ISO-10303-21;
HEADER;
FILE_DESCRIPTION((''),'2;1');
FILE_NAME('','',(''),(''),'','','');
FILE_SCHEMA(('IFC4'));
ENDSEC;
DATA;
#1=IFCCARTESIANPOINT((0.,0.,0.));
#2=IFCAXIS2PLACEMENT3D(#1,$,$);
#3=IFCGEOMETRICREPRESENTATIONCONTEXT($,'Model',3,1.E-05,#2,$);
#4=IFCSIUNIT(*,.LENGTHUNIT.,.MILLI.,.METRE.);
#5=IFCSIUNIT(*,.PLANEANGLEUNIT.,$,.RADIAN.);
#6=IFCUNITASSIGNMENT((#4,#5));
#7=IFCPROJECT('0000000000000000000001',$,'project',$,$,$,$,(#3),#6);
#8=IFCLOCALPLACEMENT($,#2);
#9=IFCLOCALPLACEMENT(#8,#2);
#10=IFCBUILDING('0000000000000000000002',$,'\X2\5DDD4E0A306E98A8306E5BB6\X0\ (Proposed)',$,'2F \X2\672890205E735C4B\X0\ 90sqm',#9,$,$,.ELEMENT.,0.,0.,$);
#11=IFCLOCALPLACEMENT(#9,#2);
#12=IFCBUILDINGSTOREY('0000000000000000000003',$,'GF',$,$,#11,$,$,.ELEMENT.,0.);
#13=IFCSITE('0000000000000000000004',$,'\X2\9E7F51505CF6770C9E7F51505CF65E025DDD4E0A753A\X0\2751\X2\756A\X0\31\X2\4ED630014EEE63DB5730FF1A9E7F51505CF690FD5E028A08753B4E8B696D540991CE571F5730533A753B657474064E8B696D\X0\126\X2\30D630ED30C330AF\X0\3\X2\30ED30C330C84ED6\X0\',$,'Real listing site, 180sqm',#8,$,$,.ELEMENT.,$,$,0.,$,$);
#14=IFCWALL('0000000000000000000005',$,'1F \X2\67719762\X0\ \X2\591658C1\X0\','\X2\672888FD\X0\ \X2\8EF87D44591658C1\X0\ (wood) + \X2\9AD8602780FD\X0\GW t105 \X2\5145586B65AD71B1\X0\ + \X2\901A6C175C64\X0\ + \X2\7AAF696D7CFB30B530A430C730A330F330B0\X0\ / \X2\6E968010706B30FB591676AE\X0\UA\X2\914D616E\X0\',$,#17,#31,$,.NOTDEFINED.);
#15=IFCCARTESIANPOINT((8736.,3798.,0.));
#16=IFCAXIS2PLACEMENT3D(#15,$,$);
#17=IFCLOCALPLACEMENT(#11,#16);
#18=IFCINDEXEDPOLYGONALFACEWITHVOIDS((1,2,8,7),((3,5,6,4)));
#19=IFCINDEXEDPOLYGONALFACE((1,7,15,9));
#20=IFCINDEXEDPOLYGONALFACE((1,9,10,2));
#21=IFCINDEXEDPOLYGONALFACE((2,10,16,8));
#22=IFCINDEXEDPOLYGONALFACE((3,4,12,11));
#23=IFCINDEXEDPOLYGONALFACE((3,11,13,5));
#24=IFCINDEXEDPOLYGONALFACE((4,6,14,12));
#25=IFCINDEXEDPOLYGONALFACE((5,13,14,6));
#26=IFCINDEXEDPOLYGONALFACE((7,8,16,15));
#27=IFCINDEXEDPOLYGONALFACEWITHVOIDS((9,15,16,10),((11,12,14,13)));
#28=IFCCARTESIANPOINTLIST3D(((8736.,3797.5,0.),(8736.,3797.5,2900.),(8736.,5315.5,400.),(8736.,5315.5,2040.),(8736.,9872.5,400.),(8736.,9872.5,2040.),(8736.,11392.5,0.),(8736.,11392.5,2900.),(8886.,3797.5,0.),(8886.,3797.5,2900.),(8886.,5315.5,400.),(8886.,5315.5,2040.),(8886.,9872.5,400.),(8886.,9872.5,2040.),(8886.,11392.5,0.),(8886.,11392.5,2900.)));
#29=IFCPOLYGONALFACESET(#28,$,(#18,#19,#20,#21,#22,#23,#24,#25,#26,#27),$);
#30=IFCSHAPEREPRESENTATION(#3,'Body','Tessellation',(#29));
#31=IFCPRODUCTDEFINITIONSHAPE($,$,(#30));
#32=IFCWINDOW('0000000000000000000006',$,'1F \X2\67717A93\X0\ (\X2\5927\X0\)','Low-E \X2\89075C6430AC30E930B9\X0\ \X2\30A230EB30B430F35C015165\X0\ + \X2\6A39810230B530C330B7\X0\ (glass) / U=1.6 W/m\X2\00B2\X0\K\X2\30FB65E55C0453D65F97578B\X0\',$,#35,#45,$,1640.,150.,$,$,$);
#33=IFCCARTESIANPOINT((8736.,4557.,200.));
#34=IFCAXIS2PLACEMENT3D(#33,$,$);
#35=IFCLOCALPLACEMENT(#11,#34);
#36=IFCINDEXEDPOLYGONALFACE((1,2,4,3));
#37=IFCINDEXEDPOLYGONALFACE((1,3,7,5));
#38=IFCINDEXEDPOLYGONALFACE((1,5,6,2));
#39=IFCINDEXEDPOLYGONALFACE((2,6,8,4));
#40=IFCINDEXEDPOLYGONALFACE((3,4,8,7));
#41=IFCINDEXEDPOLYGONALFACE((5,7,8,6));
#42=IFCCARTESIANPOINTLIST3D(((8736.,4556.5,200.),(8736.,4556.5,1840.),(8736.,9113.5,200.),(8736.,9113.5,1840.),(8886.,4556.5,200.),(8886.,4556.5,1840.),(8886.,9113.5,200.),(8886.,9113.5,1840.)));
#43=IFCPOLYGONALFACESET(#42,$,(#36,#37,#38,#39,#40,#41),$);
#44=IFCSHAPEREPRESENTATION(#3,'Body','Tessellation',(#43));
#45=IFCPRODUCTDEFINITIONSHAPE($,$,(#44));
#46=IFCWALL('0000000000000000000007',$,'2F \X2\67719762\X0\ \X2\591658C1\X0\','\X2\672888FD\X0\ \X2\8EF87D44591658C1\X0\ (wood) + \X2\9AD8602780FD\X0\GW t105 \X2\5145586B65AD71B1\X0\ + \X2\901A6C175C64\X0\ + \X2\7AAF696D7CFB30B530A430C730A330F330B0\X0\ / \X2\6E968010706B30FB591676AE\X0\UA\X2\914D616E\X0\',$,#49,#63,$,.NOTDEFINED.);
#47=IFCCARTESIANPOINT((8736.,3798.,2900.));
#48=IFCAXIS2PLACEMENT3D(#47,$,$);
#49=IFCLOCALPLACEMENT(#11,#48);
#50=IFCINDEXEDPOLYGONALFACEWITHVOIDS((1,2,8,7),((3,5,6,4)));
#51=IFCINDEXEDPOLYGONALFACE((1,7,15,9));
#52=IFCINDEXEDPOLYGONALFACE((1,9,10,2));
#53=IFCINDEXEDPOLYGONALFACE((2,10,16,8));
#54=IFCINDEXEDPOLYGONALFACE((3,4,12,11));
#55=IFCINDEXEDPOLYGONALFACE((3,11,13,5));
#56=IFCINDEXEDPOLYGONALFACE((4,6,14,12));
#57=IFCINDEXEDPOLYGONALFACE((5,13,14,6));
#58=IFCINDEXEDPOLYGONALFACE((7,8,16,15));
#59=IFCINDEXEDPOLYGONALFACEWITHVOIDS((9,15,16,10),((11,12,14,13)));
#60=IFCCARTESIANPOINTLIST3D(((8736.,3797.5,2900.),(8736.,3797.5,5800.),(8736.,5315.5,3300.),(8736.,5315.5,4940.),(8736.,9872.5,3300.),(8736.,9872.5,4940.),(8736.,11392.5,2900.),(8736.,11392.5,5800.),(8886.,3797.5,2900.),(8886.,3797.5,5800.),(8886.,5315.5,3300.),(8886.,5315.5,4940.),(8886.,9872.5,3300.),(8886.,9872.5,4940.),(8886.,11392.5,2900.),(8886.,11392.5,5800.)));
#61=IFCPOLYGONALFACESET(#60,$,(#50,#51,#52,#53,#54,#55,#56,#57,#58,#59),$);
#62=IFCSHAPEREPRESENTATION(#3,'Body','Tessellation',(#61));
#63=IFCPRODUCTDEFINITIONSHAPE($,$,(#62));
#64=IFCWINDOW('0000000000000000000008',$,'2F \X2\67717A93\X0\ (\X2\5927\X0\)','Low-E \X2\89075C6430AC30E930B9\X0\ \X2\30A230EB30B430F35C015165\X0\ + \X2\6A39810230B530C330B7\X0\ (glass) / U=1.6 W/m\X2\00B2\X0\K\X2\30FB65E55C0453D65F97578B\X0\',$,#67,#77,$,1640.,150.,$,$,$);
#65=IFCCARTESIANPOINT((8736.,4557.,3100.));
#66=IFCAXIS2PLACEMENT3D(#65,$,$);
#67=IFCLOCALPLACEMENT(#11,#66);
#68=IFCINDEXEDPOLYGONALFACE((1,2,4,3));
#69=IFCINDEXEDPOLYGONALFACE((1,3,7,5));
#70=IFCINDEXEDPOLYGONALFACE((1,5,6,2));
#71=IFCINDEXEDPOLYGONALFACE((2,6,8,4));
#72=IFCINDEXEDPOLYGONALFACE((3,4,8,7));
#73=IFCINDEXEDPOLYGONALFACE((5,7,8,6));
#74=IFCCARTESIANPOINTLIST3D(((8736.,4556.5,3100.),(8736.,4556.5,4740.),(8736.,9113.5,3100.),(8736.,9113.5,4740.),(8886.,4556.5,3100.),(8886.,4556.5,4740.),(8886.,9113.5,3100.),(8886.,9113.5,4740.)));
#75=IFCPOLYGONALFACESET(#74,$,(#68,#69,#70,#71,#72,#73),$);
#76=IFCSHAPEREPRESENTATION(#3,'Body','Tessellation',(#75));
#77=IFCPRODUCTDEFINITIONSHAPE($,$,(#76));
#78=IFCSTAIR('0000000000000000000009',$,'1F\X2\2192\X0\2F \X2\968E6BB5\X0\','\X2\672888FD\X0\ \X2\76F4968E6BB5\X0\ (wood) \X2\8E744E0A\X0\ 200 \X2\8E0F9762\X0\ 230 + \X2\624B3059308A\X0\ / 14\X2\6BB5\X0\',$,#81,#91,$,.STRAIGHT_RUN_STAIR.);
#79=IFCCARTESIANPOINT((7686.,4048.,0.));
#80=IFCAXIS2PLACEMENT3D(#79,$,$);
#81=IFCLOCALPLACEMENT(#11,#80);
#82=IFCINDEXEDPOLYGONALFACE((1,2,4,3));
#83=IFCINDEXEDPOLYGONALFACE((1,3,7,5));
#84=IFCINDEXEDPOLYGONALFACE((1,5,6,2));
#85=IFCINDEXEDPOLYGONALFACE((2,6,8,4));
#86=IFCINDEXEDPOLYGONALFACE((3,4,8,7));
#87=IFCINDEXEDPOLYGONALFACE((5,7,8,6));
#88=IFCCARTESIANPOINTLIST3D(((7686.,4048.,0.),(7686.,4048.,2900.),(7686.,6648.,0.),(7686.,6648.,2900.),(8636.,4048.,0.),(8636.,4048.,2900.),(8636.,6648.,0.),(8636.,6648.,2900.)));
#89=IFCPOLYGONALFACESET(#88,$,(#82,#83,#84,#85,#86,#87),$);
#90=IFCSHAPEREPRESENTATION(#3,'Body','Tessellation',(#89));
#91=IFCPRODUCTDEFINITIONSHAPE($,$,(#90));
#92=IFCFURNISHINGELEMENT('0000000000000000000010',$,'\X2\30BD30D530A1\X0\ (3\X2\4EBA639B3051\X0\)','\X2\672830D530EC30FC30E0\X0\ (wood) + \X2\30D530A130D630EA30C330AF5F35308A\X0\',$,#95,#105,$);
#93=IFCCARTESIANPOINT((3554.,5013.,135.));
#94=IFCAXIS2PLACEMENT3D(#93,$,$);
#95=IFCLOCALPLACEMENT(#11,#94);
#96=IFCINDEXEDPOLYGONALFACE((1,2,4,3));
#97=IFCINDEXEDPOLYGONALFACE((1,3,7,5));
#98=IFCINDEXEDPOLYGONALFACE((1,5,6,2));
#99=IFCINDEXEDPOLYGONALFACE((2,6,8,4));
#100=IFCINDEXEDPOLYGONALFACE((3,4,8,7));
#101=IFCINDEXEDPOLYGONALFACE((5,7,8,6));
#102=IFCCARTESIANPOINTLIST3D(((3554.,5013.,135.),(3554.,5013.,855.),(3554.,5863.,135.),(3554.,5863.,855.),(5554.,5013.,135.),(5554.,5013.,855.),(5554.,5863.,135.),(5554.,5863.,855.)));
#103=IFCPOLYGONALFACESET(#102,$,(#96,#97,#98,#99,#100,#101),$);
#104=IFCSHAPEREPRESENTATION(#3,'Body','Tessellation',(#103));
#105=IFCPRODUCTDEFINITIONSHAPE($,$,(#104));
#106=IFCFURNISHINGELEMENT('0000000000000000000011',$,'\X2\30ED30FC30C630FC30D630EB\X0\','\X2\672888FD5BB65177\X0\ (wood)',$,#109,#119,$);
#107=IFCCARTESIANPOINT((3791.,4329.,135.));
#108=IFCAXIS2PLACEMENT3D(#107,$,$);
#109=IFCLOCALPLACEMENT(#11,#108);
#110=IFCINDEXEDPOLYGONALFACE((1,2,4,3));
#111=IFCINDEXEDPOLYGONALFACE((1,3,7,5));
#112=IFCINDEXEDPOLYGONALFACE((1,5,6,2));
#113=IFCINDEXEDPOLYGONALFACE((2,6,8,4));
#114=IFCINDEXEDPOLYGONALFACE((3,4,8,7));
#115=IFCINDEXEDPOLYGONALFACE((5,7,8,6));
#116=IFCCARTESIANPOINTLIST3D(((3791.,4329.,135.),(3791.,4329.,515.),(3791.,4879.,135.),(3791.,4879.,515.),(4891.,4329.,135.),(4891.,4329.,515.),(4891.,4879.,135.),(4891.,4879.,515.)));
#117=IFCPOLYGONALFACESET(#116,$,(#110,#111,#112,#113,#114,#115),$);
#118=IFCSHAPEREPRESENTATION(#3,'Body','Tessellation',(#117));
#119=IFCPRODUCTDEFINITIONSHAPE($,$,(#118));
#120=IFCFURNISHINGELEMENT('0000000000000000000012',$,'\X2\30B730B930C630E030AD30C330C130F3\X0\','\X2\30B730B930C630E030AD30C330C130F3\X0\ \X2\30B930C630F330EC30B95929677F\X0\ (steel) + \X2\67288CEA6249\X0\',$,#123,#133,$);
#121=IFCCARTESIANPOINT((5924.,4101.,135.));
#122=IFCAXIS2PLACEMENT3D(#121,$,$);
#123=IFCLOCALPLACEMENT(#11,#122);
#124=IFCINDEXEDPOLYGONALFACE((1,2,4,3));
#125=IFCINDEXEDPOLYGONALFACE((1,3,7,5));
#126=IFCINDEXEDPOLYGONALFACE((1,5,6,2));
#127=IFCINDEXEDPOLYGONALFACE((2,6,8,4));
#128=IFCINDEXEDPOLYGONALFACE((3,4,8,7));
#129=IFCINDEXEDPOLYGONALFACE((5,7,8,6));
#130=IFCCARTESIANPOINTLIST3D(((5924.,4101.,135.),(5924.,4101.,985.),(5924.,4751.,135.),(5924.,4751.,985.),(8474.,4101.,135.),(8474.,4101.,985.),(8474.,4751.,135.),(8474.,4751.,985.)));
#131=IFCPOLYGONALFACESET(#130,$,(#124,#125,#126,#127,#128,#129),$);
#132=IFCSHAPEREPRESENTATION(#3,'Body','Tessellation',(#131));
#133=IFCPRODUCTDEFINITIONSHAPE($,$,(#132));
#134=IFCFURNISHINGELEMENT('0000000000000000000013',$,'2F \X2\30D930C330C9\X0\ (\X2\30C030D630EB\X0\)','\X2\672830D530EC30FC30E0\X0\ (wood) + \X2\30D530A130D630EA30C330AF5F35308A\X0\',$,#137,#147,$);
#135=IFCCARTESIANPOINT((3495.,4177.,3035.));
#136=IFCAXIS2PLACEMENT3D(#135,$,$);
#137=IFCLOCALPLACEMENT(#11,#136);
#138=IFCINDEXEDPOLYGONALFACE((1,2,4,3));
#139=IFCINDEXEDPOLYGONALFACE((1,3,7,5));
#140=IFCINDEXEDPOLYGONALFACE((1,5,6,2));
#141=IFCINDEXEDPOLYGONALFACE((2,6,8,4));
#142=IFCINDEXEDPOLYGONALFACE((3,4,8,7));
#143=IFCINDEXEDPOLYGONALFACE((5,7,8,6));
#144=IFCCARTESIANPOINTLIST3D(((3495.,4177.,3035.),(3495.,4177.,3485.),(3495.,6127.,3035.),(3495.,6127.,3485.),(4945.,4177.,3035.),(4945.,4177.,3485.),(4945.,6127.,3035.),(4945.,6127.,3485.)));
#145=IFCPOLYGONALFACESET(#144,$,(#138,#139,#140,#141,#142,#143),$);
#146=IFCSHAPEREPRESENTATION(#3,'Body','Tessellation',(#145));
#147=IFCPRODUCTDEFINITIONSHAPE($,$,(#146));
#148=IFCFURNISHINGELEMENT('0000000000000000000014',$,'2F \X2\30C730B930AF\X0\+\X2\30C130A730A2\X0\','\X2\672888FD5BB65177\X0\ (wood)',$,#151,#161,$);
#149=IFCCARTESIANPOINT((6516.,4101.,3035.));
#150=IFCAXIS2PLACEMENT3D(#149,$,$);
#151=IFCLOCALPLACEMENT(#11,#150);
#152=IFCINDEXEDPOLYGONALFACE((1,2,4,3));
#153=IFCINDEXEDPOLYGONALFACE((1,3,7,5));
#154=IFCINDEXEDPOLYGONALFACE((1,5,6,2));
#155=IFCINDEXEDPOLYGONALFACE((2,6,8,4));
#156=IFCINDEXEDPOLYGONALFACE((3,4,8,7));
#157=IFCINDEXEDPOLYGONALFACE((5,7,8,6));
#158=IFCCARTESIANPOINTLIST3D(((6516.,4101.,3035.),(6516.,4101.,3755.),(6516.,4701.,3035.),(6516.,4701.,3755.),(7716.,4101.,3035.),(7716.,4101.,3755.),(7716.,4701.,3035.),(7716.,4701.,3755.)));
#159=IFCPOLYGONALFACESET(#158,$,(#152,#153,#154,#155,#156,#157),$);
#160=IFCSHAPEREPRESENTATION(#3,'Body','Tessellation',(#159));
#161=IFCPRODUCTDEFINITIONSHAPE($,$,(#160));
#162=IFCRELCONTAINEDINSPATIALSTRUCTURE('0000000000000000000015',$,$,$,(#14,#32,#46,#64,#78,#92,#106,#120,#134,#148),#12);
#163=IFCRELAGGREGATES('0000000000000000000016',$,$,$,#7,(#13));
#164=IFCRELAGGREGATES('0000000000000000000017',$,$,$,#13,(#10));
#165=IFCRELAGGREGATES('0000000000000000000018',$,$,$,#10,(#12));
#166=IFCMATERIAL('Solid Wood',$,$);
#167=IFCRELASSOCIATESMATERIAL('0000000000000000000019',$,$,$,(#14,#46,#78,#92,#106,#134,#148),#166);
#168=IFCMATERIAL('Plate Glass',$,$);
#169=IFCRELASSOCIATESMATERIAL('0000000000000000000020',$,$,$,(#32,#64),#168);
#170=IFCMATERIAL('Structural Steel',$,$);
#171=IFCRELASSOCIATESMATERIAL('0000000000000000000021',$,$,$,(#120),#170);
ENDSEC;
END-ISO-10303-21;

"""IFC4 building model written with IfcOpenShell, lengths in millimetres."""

from ifc_helpers import new_model, si_unit, frame, frame_2d, origin, place, context, project, spatial, rectangle, extrude, material, element, fill, save


model = new_model("IFC4")

# Units and contexts
model_context = context("Model", 3, precision=1e-05, world=origin())
ifc_project = project(units=[si_unit("LENGTHUNIT", "METRE", prefix="MILLI"), si_unit("PLANEANGLEUNIT", "RADIAN")], contexts=[model_context])

# Site, building, storey
site_placement = place(None, origin())
site = spatial("IfcSite", under=ifc_project, at=site_placement, Name="鹿児島県鹿児島市川上町2751番31他、仮換地：鹿児島都市計画事業吉野土地区画整理事業126ブロック3ロット他", ObjectType="Real listing site, 180sqm", CompositionType="ELEMENT", RefElevation=0.0)
building_placement = place(site_placement, origin())
building = spatial("IfcBuilding", under=site, at=building_placement, Name="川上の風の家 (Proposed)", ObjectType="2F 木造平屋 90sqm", CompositionType="ELEMENT", ElevationOfRefHeight=0.0, ElevationOfTerrain=0.0)
storey_placement = place(building_placement, origin())
storey = spatial("IfcBuildingStorey", under=building, at=storey_placement, Name="GF", CompositionType="ELEMENT", Elevation=0.0)

# Wall, opening, window
ifc_material_1 = material(Name="Solid Wood")
wall_1_placement = place(storey_placement, frame((8736.0, 3798.0, 0.0)))
wall_1 = element("IfcWall", 1, at=wall_1_placement, inside=storey, material=ifc_material_1, Name="1F 東面 外壁", Description="木製 軸組外壁 (wood) + 高性能GW t105 充填断熱 + 通気層 + 窯業系サイディング / 準耐火・外皮UA配慮", PredefinedType="NOTDEFINED", context=model_context, shape_type="SweptSolid", body=[
    extrude(rectangle(XDim=150.0, YDim=7595.0, at=frame_2d((75.0, 3797.0))), frame((8736.0, 3798.0, 0.0)), (0.0, 0.0, 1.0), 2900.0),
])
opening_1_placement = place(storey_placement, frame((8736.0, 4557.0, 200.0)))
opening_1 = element("IfcOpeningElement", 2, at=opening_1_placement, cuts=wall_1, PredefinedType="NOTDEFINED", context=model_context, shape_type="SweptSolid", body=[
    extrude(rectangle(XDim=150.0, YDim=4557.0, at=frame_2d((75.0, 2278.0))), frame((8736.0, 4557.0, 200.0)), (0.0, 0.0, 1.0), 1640.0),
])
ifc_material_2 = material(Name="Plate Glass")
window_1_placement = place(storey_placement, frame((8736.0, 4557.0, 200.0)))
window_1 = element("IfcWindow", 3, at=window_1_placement, inside=storey, material=ifc_material_2, Name="1F 東窓 (大)", Description="Low-E 複層ガラス アルゴン封入 + 樹脂サッシ (glass) / U=1.6 W/m²K・日射取得型", OverallHeight=1640.0, OverallWidth=150.0, context=model_context, shape_type="SweptSolid", body=[
    extrude(rectangle(XDim=150.0, YDim=4557.0, at=frame_2d((75.0, 2278.0))), frame((8736.0, 4557.0, 200.0)), (0.0, 0.0, 1.0), 1640.0),
])
fill(opening_1, window_1)

# Wall, opening, window
wall_2_placement = place(storey_placement, frame((8736.0, 3798.0, 2900.0)))
wall_2 = element("IfcWall", 4, at=wall_2_placement, inside=storey, material=ifc_material_1, Name="2F 東面 外壁", Description="木製 軸組外壁 (wood) + 高性能GW t105 充填断熱 + 通気層 + 窯業系サイディング / 準耐火・外皮UA配慮", PredefinedType="NOTDEFINED", context=model_context, shape_type="SweptSolid", body=[
    extrude(rectangle(XDim=150.0, YDim=7595.0, at=frame_2d((75.0, 3797.0))), frame((8736.0, 3798.0, 2900.0)), (0.0, 0.0, 1.0), 2900.0),
])
opening_2_placement = place(storey_placement, frame((8736.0, 4557.0, 3100.0)))
opening_2 = element("IfcOpeningElement", 5, at=opening_2_placement, cuts=wall_2, PredefinedType="NOTDEFINED", context=model_context, shape_type="SweptSolid", body=[
    extrude(rectangle(XDim=150.0, YDim=4557.0, at=frame_2d((75.0, 2278.0))), frame((8736.0, 4557.0, 3100.0)), (0.0, 0.0, 1.0), 1640.0),
])
window_2_placement = place(storey_placement, frame((8736.0, 4557.0, 3100.0)))
window_2 = element("IfcWindow", 6, at=window_2_placement, inside=storey, material=ifc_material_2, Name="2F 東窓 (大)", Description="Low-E 複層ガラス アルゴン封入 + 樹脂サッシ (glass) / U=1.6 W/m²K・日射取得型", OverallHeight=1640.0, OverallWidth=150.0, context=model_context, shape_type="SweptSolid", body=[
    extrude(rectangle(XDim=150.0, YDim=4557.0, at=frame_2d((75.0, 2278.0))), frame((8736.0, 4557.0, 3100.0)), (0.0, 0.0, 1.0), 1640.0),
])
fill(opening_2, window_2)

# Stair
stair_placement = place(storey_placement, frame((7686.0, 4048.0, 0.0)))
element("IfcStair", 7, at=stair_placement, inside=storey, material=ifc_material_1, Name="1F→2F 階段", Description="木製 直階段 (wood) 蹴上 200 踏面 230 + 手すり / 14段", PredefinedType="STRAIGHT_RUN_STAIR", context=model_context, shape_type="SweptSolid", body=[
    extrude(rectangle(XDim=950.0, YDim=2600.0, at=frame_2d((475.0, 1300.0))), frame((7686.0, 4048.0, 0.0)), (0.0, 0.0, 1.0), 2900.0),
])

# Furnishing elements
furnishing_1_placement = place(storey_placement, frame((3554.0, 5013.0, 135.0)))
element("IfcFurnishingElement", 8, at=furnishing_1_placement, inside=storey, material=ifc_material_1, Name="ソファ (3人掛け)", Description="木フレーム (wood) + ファブリック張り", context=model_context, shape_type="SweptSolid", body=[
    extrude(rectangle(XDim=2000.0, YDim=850.0, at=frame_2d((1000.0, 425.0))), frame((3554.0, 5013.0, 135.0)), (0.0, 0.0, 1.0), 720.0),
])
furnishing_2_placement = place(storey_placement, frame((3791.0, 4329.0, 135.0)))
element("IfcFurnishingElement", 9, at=furnishing_2_placement, inside=storey, material=ifc_material_1, Name="ローテーブル", Description="木製家具 (wood)", context=model_context, shape_type="SweptSolid", body=[
    extrude(rectangle(XDim=1100.0, YDim=550.0, at=frame_2d((550.0, 275.0))), frame((3791.0, 4329.0, 135.0)), (0.0, 0.0, 1.0), 380.0),
])
ifc_material_3 = material(Name="Structural Steel")
furnishing_3_placement = place(storey_placement, frame((5924.0, 4101.0, 135.0)))
element("IfcFurnishingElement", 10, at=furnishing_3_placement, inside=storey, material=ifc_material_3, Name="システムキッチン", Description="システムキッチン ステンレス天板 (steel) + 木質扉", context=model_context, shape_type="SweptSolid", body=[
    extrude(rectangle(XDim=2550.0, YDim=650.0, at=frame_2d((1275.0, 325.0))), frame((5924.0, 4101.0, 135.0)), (0.0, 0.0, 1.0), 850.0),
])
furnishing_4_placement = place(storey_placement, frame((3495.0, 4177.0, 3035.0)))
element("IfcFurnishingElement", 11, at=furnishing_4_placement, inside=storey, material=ifc_material_1, Name="2F ベッド (ダブル)", Description="木フレーム (wood) + ファブリック張り", context=model_context, shape_type="SweptSolid", body=[
    extrude(rectangle(XDim=1450.0, YDim=1950.0, at=frame_2d((725.0, 975.0))), frame((3495.0, 4177.0, 3035.0)), (0.0, 0.0, 1.0), 450.0),
])
furnishing_5_placement = place(storey_placement, frame((6516.0, 4101.0, 3035.0)))
element("IfcFurnishingElement", 12, at=furnishing_5_placement, inside=storey, material=ifc_material_1, Name="2F デスク+チェア", Description="木製家具 (wood)", context=model_context, shape_type="SweptSolid", body=[
    extrude(rectangle(XDim=1200.0, YDim=600.0, at=frame_2d((600.0, 300.0))), frame((6516.0, 4101.0, 3035.0)), (0.0, 0.0, 1.0), 720.0),
])

save(model, "model.ifc")
